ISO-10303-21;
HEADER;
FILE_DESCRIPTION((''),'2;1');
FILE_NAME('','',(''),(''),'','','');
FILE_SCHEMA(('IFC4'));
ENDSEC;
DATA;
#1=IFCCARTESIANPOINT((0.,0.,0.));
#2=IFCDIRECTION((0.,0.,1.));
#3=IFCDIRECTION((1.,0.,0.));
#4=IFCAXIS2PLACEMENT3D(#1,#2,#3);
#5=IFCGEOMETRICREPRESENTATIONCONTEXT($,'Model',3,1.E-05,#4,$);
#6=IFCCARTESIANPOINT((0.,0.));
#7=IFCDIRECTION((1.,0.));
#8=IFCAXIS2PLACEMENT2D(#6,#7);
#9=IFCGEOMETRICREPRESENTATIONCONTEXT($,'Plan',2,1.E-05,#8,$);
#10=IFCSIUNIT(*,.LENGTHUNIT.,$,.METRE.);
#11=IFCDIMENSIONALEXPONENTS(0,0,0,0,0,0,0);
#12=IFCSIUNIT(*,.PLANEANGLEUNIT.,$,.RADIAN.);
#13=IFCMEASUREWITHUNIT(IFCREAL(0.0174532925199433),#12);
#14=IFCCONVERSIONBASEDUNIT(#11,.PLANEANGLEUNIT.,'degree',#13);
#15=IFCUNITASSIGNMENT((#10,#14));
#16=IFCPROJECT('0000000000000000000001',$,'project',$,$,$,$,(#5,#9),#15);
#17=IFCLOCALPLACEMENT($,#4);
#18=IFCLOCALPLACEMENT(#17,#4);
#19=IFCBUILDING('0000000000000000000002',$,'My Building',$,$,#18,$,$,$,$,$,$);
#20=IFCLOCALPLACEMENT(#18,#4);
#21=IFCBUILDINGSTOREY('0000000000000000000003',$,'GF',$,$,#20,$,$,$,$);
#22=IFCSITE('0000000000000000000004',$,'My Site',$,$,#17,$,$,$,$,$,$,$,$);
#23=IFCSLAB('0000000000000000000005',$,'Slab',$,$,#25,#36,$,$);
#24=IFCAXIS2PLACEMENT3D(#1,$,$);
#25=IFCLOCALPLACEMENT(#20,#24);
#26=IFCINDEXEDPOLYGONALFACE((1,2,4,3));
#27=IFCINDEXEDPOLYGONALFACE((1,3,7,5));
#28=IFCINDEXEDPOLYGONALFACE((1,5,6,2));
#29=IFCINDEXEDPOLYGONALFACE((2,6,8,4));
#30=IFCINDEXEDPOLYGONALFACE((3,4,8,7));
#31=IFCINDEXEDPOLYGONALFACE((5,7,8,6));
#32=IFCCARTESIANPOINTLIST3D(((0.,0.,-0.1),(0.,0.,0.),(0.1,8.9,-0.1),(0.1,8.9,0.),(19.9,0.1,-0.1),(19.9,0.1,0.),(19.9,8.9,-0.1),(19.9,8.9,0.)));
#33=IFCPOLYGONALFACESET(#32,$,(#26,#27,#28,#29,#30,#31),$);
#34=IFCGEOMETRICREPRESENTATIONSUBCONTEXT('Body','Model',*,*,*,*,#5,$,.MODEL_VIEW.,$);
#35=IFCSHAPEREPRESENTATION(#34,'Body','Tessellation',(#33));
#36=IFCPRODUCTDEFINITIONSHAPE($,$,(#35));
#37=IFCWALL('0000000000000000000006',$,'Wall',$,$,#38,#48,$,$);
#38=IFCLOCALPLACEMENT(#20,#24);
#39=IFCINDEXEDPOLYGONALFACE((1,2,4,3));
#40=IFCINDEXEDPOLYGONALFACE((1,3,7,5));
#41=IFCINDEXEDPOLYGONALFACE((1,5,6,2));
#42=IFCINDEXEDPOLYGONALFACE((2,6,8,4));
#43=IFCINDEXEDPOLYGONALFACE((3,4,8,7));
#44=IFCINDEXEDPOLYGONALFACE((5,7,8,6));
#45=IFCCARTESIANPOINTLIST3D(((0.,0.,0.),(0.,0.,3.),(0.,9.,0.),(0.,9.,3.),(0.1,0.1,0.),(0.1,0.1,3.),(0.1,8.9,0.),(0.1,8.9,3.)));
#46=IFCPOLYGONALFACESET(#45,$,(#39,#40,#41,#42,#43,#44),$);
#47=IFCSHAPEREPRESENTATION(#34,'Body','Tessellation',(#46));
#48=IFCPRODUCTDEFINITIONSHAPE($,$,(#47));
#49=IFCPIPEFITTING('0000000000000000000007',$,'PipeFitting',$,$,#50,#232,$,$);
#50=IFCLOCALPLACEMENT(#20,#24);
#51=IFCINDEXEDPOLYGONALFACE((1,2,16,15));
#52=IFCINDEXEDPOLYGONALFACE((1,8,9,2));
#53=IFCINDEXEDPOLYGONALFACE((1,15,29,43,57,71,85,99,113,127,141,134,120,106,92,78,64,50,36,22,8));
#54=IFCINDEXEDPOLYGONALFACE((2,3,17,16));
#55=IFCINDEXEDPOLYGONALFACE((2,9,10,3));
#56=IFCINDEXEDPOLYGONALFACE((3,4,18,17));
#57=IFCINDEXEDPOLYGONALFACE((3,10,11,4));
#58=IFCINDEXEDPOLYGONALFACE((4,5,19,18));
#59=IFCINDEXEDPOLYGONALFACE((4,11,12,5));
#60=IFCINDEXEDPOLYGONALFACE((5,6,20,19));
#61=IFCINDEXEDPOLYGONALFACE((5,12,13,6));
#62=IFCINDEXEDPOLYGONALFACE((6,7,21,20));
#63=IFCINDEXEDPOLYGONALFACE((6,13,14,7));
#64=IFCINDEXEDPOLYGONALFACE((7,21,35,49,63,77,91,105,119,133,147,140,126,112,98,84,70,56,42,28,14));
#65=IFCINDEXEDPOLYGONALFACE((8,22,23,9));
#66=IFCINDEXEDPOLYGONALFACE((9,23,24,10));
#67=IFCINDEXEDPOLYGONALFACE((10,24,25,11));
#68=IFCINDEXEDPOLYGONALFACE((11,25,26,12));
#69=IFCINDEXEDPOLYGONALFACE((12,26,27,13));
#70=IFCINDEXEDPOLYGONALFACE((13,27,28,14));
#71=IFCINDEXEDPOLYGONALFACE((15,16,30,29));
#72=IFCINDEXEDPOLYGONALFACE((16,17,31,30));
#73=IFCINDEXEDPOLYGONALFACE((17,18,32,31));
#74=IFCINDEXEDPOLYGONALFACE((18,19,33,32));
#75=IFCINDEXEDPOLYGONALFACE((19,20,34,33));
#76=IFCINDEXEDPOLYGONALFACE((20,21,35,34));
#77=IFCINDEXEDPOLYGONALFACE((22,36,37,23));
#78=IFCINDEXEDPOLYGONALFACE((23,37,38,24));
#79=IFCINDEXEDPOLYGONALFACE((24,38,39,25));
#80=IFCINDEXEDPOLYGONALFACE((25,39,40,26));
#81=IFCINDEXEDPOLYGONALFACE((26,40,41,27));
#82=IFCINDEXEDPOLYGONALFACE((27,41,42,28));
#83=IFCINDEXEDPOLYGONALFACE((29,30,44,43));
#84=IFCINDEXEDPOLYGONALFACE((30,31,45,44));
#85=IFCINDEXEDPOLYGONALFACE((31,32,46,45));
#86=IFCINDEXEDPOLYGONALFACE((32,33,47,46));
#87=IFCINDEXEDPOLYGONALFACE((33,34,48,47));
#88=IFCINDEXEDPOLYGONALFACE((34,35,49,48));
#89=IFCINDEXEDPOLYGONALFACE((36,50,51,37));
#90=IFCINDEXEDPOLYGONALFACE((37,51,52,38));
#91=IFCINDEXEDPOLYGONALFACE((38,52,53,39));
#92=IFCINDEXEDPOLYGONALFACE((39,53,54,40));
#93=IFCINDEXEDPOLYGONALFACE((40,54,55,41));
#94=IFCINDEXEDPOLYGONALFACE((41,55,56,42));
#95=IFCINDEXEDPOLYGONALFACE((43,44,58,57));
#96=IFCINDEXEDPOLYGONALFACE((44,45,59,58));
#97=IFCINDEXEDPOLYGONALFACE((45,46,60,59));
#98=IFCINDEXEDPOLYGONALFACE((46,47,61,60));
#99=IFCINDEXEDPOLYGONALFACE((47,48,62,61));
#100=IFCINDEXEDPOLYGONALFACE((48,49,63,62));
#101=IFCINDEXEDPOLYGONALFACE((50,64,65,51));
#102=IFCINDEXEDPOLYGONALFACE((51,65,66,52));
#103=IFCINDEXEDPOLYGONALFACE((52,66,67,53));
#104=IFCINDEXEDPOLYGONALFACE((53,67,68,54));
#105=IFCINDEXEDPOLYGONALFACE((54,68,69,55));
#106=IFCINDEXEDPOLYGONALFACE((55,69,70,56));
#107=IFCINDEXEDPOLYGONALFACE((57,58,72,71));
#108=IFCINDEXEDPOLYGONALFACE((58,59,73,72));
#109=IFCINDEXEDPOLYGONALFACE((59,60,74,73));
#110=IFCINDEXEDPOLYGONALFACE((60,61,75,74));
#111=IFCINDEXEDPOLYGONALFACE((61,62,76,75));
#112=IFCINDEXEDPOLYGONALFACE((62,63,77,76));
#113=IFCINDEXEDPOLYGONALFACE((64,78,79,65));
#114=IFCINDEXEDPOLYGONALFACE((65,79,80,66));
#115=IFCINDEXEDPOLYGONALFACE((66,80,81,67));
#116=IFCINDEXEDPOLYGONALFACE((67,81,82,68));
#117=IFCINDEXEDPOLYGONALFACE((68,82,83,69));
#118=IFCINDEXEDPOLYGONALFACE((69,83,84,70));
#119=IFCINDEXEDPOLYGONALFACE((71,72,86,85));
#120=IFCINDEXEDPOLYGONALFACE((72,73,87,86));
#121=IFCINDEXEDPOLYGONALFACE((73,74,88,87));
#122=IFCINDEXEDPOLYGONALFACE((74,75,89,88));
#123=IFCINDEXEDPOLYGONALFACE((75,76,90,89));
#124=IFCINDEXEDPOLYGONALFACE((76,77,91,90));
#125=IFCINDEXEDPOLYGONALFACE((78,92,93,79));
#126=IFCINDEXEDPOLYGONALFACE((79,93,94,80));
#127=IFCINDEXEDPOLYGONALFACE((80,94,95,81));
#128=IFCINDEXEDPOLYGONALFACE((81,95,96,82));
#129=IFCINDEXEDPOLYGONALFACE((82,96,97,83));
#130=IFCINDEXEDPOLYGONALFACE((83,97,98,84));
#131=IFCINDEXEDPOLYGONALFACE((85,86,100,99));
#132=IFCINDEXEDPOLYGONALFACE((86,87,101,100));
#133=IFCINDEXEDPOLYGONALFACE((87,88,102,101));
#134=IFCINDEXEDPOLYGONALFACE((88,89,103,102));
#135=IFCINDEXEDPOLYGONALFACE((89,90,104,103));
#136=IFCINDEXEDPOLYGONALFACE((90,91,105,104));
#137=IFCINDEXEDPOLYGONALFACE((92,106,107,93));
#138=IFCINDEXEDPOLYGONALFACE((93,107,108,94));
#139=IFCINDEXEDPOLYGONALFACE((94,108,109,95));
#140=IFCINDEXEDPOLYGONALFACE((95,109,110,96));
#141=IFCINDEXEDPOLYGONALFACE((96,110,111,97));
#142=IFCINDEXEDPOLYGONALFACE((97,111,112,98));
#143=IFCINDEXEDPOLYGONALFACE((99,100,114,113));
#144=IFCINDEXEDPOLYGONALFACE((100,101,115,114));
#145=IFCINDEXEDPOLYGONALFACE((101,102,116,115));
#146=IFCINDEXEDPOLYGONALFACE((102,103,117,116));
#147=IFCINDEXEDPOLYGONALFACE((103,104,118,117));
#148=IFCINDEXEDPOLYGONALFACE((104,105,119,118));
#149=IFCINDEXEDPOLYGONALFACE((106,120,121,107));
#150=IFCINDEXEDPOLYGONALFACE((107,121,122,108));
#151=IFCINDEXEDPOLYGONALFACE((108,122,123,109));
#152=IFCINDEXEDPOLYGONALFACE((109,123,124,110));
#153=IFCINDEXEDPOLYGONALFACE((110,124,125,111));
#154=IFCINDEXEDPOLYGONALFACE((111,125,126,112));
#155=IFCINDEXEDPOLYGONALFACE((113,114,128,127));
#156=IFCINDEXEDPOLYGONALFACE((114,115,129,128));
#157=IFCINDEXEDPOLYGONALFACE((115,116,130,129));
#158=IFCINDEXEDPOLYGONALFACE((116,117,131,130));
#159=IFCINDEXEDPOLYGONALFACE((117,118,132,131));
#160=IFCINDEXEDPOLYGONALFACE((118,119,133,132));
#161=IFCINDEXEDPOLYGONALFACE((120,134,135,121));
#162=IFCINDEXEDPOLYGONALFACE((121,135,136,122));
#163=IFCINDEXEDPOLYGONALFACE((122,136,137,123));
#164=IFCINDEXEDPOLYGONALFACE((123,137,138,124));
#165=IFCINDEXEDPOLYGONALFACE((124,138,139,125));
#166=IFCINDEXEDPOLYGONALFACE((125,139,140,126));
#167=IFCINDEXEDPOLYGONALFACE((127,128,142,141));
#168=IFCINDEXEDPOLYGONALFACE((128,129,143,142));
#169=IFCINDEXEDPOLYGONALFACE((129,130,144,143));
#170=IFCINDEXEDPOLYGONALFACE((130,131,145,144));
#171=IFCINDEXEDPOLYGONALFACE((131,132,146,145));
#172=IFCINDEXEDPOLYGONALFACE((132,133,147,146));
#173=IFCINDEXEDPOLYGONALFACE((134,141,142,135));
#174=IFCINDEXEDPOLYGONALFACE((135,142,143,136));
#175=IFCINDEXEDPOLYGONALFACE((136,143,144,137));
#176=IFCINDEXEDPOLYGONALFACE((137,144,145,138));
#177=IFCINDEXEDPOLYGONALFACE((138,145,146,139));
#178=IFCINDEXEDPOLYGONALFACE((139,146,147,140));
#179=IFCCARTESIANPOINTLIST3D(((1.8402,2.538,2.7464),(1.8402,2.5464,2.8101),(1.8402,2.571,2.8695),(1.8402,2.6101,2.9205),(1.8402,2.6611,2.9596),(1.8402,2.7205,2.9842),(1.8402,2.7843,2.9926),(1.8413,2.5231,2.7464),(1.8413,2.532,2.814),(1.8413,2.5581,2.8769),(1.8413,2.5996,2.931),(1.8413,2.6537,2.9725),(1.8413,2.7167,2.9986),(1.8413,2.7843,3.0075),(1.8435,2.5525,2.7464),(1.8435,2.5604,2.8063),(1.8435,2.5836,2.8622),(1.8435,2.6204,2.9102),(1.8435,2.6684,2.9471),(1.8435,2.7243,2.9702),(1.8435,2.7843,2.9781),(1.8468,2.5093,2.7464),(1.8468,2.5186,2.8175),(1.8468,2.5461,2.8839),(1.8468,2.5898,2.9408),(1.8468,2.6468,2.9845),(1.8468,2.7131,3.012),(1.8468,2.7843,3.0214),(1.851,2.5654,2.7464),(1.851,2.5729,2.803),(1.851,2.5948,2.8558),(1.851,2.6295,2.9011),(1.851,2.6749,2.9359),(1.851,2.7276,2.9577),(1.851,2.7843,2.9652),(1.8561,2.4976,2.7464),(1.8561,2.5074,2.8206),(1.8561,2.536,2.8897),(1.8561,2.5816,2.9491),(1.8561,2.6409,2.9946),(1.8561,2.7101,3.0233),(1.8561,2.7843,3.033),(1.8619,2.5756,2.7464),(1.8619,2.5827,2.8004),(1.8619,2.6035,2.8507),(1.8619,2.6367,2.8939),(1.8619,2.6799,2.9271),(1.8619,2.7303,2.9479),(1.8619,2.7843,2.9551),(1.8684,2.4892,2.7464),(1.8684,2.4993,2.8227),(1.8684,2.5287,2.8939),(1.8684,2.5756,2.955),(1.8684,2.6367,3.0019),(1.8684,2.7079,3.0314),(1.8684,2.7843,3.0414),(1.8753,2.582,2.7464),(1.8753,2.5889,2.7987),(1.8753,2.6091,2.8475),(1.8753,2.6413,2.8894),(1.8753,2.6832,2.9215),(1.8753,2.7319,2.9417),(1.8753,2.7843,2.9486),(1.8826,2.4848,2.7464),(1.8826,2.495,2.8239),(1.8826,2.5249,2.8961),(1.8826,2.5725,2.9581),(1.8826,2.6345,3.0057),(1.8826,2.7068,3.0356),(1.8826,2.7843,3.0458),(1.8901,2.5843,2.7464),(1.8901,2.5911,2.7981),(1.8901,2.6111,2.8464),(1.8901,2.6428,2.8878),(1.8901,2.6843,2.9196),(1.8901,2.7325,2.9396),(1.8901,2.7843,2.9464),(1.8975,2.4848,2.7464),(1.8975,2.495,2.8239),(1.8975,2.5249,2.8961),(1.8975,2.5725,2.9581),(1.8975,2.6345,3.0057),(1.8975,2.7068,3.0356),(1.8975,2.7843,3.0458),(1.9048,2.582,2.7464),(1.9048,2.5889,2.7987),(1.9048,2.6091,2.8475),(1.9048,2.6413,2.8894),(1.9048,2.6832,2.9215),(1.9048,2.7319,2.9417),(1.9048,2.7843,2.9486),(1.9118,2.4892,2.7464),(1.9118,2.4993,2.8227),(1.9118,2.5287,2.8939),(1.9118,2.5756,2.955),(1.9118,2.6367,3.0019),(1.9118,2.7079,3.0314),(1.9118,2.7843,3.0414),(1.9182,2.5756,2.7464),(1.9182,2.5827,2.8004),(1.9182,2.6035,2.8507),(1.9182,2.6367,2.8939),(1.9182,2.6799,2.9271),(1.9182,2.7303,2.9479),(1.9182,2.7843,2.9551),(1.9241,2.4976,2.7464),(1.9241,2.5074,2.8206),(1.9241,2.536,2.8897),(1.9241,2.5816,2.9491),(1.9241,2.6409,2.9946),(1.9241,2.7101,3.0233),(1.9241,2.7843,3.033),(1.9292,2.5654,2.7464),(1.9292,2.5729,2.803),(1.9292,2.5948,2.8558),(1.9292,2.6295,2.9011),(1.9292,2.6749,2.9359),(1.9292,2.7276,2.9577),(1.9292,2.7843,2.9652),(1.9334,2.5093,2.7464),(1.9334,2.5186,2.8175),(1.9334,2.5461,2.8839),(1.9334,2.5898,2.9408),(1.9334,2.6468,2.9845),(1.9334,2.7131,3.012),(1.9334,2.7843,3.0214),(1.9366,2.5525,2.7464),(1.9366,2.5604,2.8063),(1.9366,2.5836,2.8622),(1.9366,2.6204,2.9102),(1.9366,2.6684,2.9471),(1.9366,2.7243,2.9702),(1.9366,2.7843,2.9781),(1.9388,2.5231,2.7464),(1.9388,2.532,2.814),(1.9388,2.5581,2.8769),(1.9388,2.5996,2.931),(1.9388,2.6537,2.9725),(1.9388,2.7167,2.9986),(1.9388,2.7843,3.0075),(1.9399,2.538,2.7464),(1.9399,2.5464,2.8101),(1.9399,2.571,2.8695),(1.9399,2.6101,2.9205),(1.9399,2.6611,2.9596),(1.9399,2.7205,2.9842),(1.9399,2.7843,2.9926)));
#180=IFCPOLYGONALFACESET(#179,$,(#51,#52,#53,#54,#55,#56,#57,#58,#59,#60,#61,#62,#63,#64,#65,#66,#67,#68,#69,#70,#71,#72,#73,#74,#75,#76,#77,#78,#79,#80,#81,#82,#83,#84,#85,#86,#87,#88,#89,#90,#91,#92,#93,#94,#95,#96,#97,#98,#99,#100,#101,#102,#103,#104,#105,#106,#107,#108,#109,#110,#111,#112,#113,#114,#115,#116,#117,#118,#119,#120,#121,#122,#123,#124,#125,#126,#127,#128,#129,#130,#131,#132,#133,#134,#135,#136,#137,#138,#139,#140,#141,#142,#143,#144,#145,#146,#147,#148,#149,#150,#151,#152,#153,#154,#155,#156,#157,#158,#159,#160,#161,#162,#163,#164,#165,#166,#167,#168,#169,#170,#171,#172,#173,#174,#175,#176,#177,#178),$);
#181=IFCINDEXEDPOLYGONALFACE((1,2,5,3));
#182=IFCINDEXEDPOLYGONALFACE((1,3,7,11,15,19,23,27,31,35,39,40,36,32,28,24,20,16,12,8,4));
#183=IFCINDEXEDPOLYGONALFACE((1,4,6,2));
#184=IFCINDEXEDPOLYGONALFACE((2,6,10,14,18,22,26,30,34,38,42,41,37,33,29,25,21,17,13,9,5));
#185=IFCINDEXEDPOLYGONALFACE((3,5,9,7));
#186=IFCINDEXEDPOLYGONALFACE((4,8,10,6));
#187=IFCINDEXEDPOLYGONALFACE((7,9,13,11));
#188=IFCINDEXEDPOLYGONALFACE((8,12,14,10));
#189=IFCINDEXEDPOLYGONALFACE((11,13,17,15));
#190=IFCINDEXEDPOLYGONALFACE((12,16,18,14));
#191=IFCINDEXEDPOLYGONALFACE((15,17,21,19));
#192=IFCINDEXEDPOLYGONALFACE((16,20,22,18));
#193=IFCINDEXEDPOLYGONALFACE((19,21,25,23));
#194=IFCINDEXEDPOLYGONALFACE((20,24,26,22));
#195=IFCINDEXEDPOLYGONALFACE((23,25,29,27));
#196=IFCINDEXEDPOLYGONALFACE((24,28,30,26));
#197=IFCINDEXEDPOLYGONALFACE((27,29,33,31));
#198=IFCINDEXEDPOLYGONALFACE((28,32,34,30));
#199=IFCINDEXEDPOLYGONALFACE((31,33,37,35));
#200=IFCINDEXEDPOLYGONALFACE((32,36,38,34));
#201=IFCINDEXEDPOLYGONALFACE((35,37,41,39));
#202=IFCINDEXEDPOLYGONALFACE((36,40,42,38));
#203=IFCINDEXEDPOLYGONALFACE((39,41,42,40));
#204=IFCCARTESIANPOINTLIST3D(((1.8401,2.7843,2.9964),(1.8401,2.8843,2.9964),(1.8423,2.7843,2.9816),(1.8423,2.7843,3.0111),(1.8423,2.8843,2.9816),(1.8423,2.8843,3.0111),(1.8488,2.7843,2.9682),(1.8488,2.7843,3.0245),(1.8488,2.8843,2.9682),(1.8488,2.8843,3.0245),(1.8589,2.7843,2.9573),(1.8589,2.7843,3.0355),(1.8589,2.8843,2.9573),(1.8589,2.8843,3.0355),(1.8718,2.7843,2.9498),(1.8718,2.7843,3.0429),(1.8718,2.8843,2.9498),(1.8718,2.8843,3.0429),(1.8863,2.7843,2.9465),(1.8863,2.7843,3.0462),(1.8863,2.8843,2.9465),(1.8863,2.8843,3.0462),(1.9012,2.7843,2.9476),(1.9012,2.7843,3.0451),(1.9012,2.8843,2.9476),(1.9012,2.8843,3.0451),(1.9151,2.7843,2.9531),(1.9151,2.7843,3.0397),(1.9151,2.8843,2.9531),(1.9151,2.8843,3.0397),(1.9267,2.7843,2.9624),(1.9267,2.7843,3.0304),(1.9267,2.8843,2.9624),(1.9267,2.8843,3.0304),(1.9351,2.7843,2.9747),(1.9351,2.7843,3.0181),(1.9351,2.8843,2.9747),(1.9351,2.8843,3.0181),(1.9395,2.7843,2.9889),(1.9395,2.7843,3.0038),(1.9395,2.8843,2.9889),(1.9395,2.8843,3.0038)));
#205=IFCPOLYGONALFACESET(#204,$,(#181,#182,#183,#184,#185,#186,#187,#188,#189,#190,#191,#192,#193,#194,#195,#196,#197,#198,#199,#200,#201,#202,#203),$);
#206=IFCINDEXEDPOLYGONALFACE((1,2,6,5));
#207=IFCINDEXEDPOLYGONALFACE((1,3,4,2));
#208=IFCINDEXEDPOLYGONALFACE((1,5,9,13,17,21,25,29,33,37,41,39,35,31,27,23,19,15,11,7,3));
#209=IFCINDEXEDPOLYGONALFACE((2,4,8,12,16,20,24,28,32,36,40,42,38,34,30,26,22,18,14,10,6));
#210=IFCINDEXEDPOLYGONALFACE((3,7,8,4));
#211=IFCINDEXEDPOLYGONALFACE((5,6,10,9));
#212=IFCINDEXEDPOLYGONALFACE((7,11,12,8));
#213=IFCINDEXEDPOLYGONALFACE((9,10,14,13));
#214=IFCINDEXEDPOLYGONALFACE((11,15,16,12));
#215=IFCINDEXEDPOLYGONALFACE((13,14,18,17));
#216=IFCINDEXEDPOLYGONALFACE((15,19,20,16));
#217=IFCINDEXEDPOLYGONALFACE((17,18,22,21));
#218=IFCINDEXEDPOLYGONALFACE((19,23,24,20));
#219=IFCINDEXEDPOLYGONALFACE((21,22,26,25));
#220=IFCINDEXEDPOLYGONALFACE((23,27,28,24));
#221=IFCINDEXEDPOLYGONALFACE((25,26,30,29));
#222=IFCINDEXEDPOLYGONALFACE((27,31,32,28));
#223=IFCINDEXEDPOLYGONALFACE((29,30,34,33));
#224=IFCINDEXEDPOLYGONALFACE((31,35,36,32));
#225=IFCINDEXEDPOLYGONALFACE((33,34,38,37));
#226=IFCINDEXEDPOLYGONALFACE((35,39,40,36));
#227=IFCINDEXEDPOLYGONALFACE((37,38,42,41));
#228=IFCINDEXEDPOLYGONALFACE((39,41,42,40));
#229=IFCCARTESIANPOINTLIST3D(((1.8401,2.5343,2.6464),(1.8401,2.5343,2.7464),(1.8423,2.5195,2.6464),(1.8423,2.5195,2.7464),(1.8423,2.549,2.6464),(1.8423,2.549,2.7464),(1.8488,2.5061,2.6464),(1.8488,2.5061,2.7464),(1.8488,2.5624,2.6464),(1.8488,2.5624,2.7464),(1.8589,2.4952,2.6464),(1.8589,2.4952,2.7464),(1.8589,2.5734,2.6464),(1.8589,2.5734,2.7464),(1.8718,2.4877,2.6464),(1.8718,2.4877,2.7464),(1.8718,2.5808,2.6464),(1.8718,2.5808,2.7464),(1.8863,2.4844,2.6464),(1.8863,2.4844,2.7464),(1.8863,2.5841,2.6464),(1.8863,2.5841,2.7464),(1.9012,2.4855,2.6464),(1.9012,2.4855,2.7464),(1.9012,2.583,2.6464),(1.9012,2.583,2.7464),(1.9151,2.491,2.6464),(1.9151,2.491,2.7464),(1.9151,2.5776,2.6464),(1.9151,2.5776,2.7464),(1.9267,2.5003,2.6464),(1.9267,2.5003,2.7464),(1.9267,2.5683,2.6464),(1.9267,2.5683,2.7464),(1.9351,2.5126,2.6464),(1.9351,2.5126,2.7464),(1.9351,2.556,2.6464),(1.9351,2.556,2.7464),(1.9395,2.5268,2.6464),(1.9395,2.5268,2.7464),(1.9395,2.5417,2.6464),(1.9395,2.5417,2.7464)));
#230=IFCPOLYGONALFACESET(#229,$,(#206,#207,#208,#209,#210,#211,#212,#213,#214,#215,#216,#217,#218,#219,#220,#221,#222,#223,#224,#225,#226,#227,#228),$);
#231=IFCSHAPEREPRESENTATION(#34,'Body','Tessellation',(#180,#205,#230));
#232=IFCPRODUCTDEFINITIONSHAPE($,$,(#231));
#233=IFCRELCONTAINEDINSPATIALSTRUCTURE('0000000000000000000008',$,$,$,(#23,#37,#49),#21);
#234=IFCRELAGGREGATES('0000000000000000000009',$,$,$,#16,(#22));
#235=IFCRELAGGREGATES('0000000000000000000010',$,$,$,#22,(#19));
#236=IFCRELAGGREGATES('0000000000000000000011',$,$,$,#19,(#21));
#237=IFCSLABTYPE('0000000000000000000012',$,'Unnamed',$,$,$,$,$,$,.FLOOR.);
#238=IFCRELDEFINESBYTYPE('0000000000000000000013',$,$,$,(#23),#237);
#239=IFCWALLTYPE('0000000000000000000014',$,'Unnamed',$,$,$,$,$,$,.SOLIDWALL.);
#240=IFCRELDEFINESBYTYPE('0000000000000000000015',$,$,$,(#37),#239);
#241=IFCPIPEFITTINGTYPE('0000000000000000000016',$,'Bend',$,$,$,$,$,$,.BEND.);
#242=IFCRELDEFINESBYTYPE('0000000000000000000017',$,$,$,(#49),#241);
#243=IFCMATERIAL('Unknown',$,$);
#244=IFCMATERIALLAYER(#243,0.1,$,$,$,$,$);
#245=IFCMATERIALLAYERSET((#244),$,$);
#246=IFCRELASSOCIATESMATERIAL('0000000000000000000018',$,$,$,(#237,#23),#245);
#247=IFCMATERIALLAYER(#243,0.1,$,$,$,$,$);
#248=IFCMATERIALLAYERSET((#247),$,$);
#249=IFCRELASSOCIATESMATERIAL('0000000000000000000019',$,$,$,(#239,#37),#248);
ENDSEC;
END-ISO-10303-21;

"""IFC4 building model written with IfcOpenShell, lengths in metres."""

from ifc_helpers import new_model, entity, si_unit, converted_unit, frame, origin_with_axes, origin_2d_with_axis, place, context, subcontext, project, spatial, line, indexed_curve, circle, outline, extrude, source, transform, mapped, material, layer, layer_set, layer_usage, type_object, type_shapes, element, save


model = new_model("IFC4")

# Units and contexts
model_context = context("Model", 3, precision=1e-05, world=origin_with_axes())
plan_context = context("Plan", 2, precision=1e-05, world=origin_2d_with_axis())
body_context_1 = subcontext(model_context, "Body", "Model", "MODEL_VIEW")
ifc_project = project(units=[si_unit("LENGTHUNIT", "METRE"), converted_unit("PLANEANGLEUNIT", "degree", entity("IfcReal", 0.0174532925199433), si_unit("PLANEANGLEUNIT", "RADIAN"), dimensions=[0, 0, 0, 0, 0, 0, 0])], contexts=[model_context, plan_context])

# Site, building, storey
site_placement = place(None, origin_with_axes())
site = spatial("IfcSite", under=ifc_project, at=site_placement, Name="My Site")
building_placement = place(site_placement, origin_with_axes())
building = spatial("IfcBuilding", under=site, at=building_placement, Name="My Building")
storey_placement = place(building_placement, origin_with_axes())
storey = spatial("IfcBuildingStorey", under=building, at=storey_placement, Name="GF")

# Slab
ifc_material = material(Name="Unknown")
ifc_layer_1 = layer(ifc_material, 0.1)
ifc_layer_set_1 = layer_set([ifc_layer_1])
ifc_layer_usage_1 = layer_usage(ifc_layer_set_1, "AXIS3", "POSITIVE", -0.1)
slab_type = type_object("IfcSlabType", Name="Unnamed", PredefinedType="FLOOR", material=ifc_layer_set_1)
slab_placement = place(storey_placement, frame((0.1, 8.9, 0.0), z_axis=(0.0, 0.0, 1.0), x_axis=(1.0, 0.0, 0.0)))
element("IfcSlab", 1, at=slab_placement, inside=storey, type_object=slab_type, material=ifc_layer_usage_1, Name="Slab", context=body_context_1, shape_type="SweptSolid", body=[
    extrude(outline(indexed_curve([(0.0, 0.0), (19.8, 0.0), (19.8, -8.8), (-0.1, -8.9), (0.0, 0.0)])), frame((0.0, 0.0, -0.1), z_axis=(0.0, 0.0, 1.0), x_axis=(1.0, 0.0, 0.0)), (0.0, 0.0, 1.0), 0.1),
])

# Shared definitions
ifc_layer_2 = layer(ifc_material, 0.1)
ifc_layer_set_2 = layer_set([ifc_layer_2])
wall_type = type_object("IfcWallType", Name="Unnamed", PredefinedType="SOLIDWALL", material=ifc_layer_set_2)

# Wall
ifc_layer_usage_2 = layer_usage(ifc_layer_set_2, "AXIS2", "POSITIVE", 0.0)
wall_1_placement = place(storey_placement, frame((0.0, 9.0, 0.0), z_axis=(0.0, 0.0, 1.0), x_axis=(0.0, -1.0, 0.0)))
element("IfcWall", 2, at=wall_1_placement, inside=storey, type_object=wall_type, material=ifc_layer_usage_2, Name="Wall", context=body_context_1, shape_type="SweptSolid", body=[
    extrude(outline(indexed_curve([(0.0, 0.0), (0.1, 0.1), (8.9, 0.1), (9.0, 0.0)], segments=[line(1, 2, 3, 4, 1)])), origin_with_axes(), (0.0, 0.0, 1.0), 3.0),
])

# Pipe fitting
pipe_fitting_type = type_object("IfcPipeFittingType", Name="Bend", PredefinedType="BEND")
shared_shape_1 = source(origin_with_axes(), body_context_1, "Body", "SolidModel", [
    entity("IfcSweptDiskSolid", entity("IfcIndexedPolyCurve", entity("IfcCartesianPointList3D", [[0.0, 0.0, -0.1], [0.0, -0.0732, -0.2768], [0.0, -0.25, -0.35]]), [entity("IfcArcIndex", [1, 2, 3])]), 0.05),
    extrude(circle(Radius=0.05), origin_with_axes(), (0.0, 0.0, -1.0), 0.1),
    extrude(circle(Radius=0.05), frame((0.0, -0.25, -0.35), z_axis=(0.0, -1.0, 0.0), x_axis=(1.0, 0.0, 0.0)), (0.0, 0.0, 1.0), 0.1),
])
type_shapes(pipe_fitting_type, [shared_shape_1])
pipe_fitting_placement = place(storey_placement, frame((1.8901, 2.8843, 2.9964), z_axis=(0.0, 1.0, 0.0), x_axis=(-1.0, 0.0, 0.0)))
element("IfcPipeFitting", 3, at=pipe_fitting_placement, inside=storey, type_object=pipe_fitting_type, Name="PipeFitting", context=body_context_1, shape_type="MappedRepresentation", body=[
    mapped(shared_shape_1, transform((0.0, 0.0, 0.0), x_axis=(1.0, 0.0, 0.0), y_axis=(0.0, 1.0, 0.0), z_axis=(0.0, 0.0, 1.0), scale=1.0)),
])

save(model, "model.ifc")
